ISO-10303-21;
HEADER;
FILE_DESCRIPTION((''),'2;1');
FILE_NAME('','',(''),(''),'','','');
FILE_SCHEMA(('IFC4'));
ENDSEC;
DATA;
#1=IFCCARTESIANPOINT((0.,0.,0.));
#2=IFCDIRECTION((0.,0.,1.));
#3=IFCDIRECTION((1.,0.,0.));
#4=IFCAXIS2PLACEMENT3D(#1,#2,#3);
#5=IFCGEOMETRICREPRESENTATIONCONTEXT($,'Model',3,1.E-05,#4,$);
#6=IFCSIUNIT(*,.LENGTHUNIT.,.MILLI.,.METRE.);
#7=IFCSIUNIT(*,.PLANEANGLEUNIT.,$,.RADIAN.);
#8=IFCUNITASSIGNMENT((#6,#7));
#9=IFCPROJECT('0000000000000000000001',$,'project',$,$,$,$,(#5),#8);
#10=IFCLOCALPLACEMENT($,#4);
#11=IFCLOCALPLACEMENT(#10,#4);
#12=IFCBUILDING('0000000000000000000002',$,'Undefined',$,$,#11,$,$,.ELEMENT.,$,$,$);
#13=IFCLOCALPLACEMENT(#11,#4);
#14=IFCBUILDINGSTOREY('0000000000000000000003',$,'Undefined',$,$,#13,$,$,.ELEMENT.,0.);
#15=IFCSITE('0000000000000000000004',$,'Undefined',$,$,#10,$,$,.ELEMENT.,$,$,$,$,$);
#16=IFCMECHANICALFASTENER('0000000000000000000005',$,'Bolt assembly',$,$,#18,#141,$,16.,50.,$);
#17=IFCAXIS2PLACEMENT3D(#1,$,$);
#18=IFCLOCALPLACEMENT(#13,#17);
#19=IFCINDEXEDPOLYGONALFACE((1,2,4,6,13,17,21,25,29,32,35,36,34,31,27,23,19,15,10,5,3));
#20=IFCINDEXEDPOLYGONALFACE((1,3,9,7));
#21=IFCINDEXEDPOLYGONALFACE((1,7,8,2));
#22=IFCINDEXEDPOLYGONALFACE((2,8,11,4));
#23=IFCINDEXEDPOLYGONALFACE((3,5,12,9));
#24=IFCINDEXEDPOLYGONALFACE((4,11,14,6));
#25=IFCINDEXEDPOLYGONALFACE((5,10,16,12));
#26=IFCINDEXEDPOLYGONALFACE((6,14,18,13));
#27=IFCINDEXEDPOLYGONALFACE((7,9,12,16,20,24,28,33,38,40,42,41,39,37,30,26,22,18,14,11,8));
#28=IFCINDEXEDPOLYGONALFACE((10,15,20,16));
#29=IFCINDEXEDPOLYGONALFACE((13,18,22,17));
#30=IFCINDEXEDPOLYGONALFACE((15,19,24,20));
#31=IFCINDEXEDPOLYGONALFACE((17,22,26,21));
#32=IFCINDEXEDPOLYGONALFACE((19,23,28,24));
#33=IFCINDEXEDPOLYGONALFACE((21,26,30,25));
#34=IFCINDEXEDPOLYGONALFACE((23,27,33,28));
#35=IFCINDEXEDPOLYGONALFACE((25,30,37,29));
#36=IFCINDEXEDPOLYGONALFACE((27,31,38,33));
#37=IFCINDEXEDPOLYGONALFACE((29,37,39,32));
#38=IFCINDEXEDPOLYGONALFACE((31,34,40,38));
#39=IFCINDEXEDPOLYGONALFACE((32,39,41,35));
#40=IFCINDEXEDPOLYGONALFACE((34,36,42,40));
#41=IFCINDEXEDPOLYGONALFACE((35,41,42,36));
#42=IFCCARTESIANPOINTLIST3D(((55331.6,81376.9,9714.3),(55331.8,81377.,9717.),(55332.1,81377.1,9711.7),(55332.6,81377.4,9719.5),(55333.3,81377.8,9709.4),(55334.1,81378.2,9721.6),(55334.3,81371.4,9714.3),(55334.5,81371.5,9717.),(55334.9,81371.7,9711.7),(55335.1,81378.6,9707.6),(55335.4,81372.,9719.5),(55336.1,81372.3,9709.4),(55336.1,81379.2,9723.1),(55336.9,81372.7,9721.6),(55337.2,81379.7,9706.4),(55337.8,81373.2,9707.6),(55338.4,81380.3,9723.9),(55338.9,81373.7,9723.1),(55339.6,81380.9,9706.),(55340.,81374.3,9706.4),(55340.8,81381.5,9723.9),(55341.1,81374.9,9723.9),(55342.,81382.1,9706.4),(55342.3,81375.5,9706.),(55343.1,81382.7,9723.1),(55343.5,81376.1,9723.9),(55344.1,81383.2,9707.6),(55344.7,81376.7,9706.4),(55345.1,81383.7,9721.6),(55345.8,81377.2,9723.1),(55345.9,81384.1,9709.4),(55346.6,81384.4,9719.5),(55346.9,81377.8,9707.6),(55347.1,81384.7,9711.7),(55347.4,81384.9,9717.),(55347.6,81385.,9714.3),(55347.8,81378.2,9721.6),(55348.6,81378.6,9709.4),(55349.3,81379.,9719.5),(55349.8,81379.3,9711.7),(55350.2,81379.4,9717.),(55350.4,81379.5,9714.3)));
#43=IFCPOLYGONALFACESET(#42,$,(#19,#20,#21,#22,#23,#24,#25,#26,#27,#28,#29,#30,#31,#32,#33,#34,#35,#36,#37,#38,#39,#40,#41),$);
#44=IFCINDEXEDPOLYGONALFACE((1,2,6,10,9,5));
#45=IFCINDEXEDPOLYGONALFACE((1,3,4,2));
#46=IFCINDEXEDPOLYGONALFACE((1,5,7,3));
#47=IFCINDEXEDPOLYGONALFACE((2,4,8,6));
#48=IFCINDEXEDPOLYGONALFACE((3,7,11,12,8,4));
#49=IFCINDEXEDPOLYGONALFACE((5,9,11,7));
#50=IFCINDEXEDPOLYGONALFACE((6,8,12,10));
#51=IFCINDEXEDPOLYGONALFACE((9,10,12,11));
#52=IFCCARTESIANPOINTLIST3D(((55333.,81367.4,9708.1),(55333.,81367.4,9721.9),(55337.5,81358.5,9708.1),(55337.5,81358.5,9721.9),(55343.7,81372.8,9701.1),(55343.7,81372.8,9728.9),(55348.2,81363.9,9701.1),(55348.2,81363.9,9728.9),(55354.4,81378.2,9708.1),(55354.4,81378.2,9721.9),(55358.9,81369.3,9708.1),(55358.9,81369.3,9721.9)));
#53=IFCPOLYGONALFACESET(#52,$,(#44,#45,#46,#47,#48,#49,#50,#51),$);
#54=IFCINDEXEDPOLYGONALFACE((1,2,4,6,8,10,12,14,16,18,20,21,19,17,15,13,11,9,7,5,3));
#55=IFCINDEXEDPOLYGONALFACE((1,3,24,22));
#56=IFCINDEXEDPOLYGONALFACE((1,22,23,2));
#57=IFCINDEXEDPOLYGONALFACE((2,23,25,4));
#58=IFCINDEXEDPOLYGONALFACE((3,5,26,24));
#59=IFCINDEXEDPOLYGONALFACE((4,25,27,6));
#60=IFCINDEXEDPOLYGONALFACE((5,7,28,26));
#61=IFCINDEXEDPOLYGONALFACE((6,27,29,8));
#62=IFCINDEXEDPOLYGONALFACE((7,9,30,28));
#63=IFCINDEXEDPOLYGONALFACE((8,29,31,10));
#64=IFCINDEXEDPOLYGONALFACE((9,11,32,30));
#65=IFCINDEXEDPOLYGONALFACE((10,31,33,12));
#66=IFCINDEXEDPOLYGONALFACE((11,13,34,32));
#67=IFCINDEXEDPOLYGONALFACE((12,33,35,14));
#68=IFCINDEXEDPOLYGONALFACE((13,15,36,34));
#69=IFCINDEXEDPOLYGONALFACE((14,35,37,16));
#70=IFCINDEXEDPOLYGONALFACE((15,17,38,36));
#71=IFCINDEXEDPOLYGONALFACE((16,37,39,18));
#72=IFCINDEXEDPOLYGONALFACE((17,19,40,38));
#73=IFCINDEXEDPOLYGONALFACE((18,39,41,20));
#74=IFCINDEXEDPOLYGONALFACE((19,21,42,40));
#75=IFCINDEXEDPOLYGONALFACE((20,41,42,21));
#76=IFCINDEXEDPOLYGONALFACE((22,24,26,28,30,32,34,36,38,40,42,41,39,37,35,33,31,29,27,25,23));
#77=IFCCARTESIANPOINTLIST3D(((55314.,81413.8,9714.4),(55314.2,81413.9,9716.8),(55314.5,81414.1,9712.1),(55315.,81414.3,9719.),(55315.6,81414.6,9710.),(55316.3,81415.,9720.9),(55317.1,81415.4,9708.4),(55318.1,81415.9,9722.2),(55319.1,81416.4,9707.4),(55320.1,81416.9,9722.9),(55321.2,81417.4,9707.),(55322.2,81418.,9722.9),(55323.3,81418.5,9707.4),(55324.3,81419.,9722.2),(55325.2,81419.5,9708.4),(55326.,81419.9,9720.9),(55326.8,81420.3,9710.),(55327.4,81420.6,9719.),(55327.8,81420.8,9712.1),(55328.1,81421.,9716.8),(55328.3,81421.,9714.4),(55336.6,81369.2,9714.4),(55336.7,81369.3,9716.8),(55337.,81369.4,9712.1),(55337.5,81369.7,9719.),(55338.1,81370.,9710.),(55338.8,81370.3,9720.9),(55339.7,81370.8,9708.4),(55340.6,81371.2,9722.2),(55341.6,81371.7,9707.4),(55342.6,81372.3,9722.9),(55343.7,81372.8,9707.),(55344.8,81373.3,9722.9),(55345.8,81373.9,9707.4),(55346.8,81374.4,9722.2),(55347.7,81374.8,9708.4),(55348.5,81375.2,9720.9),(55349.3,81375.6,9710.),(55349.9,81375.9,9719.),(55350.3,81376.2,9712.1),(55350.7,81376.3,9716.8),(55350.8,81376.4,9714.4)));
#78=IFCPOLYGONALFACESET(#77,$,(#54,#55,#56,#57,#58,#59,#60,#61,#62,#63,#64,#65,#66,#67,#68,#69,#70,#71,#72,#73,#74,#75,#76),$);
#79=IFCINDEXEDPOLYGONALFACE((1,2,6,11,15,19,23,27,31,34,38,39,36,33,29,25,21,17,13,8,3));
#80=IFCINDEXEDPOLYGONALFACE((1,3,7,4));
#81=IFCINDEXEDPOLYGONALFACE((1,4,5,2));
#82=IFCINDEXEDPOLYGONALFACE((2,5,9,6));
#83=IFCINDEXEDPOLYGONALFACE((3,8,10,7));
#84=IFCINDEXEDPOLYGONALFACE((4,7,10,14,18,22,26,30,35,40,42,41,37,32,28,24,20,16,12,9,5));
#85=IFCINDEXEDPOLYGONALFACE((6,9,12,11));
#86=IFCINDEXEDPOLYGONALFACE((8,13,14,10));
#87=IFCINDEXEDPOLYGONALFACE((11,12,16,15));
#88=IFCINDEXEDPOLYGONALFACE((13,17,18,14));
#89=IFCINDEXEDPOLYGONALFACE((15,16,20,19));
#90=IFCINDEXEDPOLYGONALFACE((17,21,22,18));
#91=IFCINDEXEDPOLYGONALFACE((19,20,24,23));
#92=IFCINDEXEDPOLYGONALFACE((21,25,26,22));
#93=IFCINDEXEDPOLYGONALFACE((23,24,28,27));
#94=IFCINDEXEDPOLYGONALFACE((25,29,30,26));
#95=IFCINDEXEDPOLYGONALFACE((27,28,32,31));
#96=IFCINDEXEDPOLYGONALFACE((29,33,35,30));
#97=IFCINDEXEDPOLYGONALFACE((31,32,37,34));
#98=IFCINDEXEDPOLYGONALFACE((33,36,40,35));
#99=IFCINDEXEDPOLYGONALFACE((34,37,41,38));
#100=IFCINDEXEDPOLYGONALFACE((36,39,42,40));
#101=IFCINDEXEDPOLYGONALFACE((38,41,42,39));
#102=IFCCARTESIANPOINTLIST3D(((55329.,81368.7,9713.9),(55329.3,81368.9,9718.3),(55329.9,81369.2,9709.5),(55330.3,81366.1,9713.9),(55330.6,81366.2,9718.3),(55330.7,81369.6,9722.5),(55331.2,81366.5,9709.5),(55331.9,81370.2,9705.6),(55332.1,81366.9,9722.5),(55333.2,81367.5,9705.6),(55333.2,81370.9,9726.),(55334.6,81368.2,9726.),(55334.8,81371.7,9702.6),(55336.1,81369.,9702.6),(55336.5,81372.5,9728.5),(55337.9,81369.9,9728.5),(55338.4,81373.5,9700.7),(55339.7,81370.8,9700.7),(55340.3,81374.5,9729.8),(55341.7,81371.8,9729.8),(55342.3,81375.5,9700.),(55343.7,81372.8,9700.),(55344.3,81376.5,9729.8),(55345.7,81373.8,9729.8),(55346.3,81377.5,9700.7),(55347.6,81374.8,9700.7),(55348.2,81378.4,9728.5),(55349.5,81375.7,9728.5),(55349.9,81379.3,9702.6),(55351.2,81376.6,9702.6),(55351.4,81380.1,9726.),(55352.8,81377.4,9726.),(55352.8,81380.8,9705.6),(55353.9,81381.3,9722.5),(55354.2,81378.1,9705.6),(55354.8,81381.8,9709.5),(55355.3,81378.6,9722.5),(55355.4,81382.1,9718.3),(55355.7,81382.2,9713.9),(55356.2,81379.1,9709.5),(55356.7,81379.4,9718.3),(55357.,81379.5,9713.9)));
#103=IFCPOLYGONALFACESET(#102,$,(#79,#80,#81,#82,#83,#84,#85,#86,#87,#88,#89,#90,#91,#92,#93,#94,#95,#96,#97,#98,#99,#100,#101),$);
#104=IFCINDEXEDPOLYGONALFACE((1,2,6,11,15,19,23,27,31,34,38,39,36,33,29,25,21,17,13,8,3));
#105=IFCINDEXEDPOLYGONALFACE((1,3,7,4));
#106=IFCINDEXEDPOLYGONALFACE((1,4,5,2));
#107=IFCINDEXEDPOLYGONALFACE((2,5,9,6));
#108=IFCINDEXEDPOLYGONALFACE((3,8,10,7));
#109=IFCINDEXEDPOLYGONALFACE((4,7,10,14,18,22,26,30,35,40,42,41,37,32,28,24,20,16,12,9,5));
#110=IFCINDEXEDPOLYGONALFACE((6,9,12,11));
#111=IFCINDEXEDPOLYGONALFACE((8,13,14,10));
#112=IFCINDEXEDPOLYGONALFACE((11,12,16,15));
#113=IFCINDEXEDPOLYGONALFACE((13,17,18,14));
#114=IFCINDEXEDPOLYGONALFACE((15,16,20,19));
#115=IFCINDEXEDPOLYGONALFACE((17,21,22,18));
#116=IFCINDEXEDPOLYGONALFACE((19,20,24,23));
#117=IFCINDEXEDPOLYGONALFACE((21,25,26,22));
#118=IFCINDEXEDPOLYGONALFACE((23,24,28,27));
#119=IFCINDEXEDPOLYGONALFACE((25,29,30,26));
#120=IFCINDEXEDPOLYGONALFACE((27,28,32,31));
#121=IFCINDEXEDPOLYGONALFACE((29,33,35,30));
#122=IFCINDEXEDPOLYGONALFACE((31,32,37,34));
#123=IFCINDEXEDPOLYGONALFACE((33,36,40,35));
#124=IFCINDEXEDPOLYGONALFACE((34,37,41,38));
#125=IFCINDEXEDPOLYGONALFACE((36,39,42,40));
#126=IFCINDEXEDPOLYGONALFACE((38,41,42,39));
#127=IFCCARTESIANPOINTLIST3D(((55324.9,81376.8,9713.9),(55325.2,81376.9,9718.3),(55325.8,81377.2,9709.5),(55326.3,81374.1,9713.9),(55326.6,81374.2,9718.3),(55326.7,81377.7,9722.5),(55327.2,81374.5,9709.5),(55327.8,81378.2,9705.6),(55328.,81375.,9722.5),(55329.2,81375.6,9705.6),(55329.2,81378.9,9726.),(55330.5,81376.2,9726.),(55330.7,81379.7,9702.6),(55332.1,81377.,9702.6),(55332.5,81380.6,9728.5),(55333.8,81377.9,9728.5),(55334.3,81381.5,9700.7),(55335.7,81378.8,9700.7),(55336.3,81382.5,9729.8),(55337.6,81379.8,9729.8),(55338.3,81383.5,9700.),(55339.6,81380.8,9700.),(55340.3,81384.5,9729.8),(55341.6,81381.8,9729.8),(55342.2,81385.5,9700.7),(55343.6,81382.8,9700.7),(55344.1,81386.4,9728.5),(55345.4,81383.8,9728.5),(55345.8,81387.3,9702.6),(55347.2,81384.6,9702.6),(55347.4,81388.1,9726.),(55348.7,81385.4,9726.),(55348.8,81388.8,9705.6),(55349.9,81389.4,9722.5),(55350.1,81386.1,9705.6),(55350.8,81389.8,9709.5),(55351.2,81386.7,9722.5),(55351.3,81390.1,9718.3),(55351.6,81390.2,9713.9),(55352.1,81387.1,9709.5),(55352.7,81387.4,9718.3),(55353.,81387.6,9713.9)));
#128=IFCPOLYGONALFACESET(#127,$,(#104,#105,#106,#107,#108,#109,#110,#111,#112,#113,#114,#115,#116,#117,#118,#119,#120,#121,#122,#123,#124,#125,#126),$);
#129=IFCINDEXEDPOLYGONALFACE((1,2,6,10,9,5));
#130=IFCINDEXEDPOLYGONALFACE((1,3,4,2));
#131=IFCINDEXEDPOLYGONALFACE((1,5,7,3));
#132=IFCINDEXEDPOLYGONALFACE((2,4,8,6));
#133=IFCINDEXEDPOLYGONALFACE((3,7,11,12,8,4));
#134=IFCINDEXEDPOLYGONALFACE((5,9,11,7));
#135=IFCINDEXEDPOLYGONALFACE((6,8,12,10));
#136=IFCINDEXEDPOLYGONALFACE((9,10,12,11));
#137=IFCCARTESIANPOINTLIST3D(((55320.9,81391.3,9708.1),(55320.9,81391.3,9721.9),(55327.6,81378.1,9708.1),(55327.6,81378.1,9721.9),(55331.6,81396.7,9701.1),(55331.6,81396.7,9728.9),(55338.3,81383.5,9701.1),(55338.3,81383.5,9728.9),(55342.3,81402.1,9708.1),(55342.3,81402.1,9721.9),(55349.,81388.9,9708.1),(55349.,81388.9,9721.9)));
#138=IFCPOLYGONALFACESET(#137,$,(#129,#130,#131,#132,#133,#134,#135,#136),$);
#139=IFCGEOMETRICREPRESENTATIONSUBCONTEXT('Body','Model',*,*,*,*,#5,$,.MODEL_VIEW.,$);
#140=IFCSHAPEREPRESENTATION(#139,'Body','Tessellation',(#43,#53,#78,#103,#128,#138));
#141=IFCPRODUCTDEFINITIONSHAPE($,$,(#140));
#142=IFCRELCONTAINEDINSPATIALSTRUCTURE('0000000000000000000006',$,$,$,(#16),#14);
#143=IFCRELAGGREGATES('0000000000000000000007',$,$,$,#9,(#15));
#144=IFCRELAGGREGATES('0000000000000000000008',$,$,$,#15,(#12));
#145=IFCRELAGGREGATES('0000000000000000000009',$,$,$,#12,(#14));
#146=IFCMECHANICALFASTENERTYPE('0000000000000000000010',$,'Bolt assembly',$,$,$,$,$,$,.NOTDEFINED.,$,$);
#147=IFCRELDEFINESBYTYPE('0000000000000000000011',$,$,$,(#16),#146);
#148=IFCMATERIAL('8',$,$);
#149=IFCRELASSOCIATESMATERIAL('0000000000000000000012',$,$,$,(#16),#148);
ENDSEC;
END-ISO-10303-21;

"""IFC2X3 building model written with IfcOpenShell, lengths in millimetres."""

from ifc_helpers import new_model, si_unit, frame, origin_with_axes, origin_2d_with_axis, place, context, subcontext, project, spatial, polyline, circle, outline, extrude, source, transform, mapped, material, type_object, element, save


model = new_model("IFC2X3")

# Units and contexts
model_context = context("Model", 3, precision=1e-05, world=origin_with_axes())
body_context = subcontext(model_context, "Body", "Model", "MODEL_VIEW")
ifc_project = project(units=[si_unit("LENGTHUNIT", "METRE", prefix="MILLI"), si_unit("PLANEANGLEUNIT", "RADIAN")], contexts=[model_context])

# Site, building, storey
site_placement = place(None, origin_with_axes())
site = spatial("IfcSite", under=ifc_project, at=site_placement, Name="Undefined", CompositionType="ELEMENT")
building_placement = place(site_placement, origin_with_axes())
building = spatial("IfcBuilding", under=site, at=building_placement, Name="Undefined", CompositionType="ELEMENT")
storey_placement = place(building_placement, origin_with_axes())
storey = spatial("IfcBuildingStorey", under=building, at=storey_placement, Name="Undefined", CompositionType="ELEMENT", Elevation=0.0)

# Mechanical fastener
ifc_material_1 = material(Name="8")
mechanical_fastener_type = type_object("IfcMechanicalFastenerType", Name="Bolt assembly")
shared_shape_1 = source(origin_with_axes(), body_context, "Body", "SweptSolid", [
    extrude(circle(Radius=9.0, at=origin_2d_with_axis()), frame((0.0, 0.0, 0.0), z_axis=(0.0, 1.0, 0.0), x_axis=(1.0, 0.0, 0.0)), (0.0, 0.0, 1.0), 6.1),
    extrude(outline(polyline([(13.9, 0.0), (6.9, 12.0), (-6.9, 12.0), (-13.9, 0.0), (-6.9, -12.0), (6.9, -12.0), (13.9, 0.0)])), frame((0.0, -13.0, 0.0), z_axis=(0.0, 1.0, 0.0), x_axis=(1.0, 0.0, 0.0)), (0.0, 0.0, 1.0), 10.0),
    extrude(circle(Radius=8.0, at=origin_2d_with_axis()), frame((0.0, -3.0, 0.0), z_axis=(0.0, 1.0, 0.0), x_axis=(1.0, 0.0, 0.0)), (0.0, 0.0, 1.0), 50.0),
    extrude(circle(Radius=15.0, at=origin_2d_with_axis()), frame((0.0, -3.0, 0.0), z_axis=(0.0, 1.0, 0.0), x_axis=(1.0, 0.0, 0.0)), (0.0, 0.0, 1.0), 3.0),
    extrude(circle(Radius=15.0, at=origin_2d_with_axis()), frame((0.0, 6.0, 0.0), z_axis=(0.0, 1.0, 0.0), x_axis=(1.0, 0.0, 0.0)), (0.0, 0.0, 1.0), 3.0),
    extrude(outline(polyline([(13.9, 0.0), (6.9, 12.0), (-6.9, 12.0), (-13.9, 0.0), (-6.9, -12.0), (6.9, -12.0), (13.9, 0.0)])), frame((0.0, 9.0, 0.0), z_axis=(0.0, 1.0, 0.0), x_axis=(1.0, 0.0, 0.0)), (0.0, 0.0, 1.0), 14.8),
])
mechanical_fastener_1_placement = place(storey_placement, frame((55342.3, 81375.5, 9715.0), z_axis=(0.892821, 0.450411, 0.0), x_axis=(-0.000057, 0.000114, -1.0)))
element("IfcMechanicalFastener", 1, at=mechanical_fastener_1_placement, inside=storey, type_object=mechanical_fastener_type, material=ifc_material_1, Name="Bolt assembly", NominalDiameter=16.0, NominalLength=50.0, context=body_context, shape_type="MappedRepresentation", body=[
    mapped(shared_shape_1, transform((0.0, 0.0, 0.0))),
])

save(model, "model.ifc")
